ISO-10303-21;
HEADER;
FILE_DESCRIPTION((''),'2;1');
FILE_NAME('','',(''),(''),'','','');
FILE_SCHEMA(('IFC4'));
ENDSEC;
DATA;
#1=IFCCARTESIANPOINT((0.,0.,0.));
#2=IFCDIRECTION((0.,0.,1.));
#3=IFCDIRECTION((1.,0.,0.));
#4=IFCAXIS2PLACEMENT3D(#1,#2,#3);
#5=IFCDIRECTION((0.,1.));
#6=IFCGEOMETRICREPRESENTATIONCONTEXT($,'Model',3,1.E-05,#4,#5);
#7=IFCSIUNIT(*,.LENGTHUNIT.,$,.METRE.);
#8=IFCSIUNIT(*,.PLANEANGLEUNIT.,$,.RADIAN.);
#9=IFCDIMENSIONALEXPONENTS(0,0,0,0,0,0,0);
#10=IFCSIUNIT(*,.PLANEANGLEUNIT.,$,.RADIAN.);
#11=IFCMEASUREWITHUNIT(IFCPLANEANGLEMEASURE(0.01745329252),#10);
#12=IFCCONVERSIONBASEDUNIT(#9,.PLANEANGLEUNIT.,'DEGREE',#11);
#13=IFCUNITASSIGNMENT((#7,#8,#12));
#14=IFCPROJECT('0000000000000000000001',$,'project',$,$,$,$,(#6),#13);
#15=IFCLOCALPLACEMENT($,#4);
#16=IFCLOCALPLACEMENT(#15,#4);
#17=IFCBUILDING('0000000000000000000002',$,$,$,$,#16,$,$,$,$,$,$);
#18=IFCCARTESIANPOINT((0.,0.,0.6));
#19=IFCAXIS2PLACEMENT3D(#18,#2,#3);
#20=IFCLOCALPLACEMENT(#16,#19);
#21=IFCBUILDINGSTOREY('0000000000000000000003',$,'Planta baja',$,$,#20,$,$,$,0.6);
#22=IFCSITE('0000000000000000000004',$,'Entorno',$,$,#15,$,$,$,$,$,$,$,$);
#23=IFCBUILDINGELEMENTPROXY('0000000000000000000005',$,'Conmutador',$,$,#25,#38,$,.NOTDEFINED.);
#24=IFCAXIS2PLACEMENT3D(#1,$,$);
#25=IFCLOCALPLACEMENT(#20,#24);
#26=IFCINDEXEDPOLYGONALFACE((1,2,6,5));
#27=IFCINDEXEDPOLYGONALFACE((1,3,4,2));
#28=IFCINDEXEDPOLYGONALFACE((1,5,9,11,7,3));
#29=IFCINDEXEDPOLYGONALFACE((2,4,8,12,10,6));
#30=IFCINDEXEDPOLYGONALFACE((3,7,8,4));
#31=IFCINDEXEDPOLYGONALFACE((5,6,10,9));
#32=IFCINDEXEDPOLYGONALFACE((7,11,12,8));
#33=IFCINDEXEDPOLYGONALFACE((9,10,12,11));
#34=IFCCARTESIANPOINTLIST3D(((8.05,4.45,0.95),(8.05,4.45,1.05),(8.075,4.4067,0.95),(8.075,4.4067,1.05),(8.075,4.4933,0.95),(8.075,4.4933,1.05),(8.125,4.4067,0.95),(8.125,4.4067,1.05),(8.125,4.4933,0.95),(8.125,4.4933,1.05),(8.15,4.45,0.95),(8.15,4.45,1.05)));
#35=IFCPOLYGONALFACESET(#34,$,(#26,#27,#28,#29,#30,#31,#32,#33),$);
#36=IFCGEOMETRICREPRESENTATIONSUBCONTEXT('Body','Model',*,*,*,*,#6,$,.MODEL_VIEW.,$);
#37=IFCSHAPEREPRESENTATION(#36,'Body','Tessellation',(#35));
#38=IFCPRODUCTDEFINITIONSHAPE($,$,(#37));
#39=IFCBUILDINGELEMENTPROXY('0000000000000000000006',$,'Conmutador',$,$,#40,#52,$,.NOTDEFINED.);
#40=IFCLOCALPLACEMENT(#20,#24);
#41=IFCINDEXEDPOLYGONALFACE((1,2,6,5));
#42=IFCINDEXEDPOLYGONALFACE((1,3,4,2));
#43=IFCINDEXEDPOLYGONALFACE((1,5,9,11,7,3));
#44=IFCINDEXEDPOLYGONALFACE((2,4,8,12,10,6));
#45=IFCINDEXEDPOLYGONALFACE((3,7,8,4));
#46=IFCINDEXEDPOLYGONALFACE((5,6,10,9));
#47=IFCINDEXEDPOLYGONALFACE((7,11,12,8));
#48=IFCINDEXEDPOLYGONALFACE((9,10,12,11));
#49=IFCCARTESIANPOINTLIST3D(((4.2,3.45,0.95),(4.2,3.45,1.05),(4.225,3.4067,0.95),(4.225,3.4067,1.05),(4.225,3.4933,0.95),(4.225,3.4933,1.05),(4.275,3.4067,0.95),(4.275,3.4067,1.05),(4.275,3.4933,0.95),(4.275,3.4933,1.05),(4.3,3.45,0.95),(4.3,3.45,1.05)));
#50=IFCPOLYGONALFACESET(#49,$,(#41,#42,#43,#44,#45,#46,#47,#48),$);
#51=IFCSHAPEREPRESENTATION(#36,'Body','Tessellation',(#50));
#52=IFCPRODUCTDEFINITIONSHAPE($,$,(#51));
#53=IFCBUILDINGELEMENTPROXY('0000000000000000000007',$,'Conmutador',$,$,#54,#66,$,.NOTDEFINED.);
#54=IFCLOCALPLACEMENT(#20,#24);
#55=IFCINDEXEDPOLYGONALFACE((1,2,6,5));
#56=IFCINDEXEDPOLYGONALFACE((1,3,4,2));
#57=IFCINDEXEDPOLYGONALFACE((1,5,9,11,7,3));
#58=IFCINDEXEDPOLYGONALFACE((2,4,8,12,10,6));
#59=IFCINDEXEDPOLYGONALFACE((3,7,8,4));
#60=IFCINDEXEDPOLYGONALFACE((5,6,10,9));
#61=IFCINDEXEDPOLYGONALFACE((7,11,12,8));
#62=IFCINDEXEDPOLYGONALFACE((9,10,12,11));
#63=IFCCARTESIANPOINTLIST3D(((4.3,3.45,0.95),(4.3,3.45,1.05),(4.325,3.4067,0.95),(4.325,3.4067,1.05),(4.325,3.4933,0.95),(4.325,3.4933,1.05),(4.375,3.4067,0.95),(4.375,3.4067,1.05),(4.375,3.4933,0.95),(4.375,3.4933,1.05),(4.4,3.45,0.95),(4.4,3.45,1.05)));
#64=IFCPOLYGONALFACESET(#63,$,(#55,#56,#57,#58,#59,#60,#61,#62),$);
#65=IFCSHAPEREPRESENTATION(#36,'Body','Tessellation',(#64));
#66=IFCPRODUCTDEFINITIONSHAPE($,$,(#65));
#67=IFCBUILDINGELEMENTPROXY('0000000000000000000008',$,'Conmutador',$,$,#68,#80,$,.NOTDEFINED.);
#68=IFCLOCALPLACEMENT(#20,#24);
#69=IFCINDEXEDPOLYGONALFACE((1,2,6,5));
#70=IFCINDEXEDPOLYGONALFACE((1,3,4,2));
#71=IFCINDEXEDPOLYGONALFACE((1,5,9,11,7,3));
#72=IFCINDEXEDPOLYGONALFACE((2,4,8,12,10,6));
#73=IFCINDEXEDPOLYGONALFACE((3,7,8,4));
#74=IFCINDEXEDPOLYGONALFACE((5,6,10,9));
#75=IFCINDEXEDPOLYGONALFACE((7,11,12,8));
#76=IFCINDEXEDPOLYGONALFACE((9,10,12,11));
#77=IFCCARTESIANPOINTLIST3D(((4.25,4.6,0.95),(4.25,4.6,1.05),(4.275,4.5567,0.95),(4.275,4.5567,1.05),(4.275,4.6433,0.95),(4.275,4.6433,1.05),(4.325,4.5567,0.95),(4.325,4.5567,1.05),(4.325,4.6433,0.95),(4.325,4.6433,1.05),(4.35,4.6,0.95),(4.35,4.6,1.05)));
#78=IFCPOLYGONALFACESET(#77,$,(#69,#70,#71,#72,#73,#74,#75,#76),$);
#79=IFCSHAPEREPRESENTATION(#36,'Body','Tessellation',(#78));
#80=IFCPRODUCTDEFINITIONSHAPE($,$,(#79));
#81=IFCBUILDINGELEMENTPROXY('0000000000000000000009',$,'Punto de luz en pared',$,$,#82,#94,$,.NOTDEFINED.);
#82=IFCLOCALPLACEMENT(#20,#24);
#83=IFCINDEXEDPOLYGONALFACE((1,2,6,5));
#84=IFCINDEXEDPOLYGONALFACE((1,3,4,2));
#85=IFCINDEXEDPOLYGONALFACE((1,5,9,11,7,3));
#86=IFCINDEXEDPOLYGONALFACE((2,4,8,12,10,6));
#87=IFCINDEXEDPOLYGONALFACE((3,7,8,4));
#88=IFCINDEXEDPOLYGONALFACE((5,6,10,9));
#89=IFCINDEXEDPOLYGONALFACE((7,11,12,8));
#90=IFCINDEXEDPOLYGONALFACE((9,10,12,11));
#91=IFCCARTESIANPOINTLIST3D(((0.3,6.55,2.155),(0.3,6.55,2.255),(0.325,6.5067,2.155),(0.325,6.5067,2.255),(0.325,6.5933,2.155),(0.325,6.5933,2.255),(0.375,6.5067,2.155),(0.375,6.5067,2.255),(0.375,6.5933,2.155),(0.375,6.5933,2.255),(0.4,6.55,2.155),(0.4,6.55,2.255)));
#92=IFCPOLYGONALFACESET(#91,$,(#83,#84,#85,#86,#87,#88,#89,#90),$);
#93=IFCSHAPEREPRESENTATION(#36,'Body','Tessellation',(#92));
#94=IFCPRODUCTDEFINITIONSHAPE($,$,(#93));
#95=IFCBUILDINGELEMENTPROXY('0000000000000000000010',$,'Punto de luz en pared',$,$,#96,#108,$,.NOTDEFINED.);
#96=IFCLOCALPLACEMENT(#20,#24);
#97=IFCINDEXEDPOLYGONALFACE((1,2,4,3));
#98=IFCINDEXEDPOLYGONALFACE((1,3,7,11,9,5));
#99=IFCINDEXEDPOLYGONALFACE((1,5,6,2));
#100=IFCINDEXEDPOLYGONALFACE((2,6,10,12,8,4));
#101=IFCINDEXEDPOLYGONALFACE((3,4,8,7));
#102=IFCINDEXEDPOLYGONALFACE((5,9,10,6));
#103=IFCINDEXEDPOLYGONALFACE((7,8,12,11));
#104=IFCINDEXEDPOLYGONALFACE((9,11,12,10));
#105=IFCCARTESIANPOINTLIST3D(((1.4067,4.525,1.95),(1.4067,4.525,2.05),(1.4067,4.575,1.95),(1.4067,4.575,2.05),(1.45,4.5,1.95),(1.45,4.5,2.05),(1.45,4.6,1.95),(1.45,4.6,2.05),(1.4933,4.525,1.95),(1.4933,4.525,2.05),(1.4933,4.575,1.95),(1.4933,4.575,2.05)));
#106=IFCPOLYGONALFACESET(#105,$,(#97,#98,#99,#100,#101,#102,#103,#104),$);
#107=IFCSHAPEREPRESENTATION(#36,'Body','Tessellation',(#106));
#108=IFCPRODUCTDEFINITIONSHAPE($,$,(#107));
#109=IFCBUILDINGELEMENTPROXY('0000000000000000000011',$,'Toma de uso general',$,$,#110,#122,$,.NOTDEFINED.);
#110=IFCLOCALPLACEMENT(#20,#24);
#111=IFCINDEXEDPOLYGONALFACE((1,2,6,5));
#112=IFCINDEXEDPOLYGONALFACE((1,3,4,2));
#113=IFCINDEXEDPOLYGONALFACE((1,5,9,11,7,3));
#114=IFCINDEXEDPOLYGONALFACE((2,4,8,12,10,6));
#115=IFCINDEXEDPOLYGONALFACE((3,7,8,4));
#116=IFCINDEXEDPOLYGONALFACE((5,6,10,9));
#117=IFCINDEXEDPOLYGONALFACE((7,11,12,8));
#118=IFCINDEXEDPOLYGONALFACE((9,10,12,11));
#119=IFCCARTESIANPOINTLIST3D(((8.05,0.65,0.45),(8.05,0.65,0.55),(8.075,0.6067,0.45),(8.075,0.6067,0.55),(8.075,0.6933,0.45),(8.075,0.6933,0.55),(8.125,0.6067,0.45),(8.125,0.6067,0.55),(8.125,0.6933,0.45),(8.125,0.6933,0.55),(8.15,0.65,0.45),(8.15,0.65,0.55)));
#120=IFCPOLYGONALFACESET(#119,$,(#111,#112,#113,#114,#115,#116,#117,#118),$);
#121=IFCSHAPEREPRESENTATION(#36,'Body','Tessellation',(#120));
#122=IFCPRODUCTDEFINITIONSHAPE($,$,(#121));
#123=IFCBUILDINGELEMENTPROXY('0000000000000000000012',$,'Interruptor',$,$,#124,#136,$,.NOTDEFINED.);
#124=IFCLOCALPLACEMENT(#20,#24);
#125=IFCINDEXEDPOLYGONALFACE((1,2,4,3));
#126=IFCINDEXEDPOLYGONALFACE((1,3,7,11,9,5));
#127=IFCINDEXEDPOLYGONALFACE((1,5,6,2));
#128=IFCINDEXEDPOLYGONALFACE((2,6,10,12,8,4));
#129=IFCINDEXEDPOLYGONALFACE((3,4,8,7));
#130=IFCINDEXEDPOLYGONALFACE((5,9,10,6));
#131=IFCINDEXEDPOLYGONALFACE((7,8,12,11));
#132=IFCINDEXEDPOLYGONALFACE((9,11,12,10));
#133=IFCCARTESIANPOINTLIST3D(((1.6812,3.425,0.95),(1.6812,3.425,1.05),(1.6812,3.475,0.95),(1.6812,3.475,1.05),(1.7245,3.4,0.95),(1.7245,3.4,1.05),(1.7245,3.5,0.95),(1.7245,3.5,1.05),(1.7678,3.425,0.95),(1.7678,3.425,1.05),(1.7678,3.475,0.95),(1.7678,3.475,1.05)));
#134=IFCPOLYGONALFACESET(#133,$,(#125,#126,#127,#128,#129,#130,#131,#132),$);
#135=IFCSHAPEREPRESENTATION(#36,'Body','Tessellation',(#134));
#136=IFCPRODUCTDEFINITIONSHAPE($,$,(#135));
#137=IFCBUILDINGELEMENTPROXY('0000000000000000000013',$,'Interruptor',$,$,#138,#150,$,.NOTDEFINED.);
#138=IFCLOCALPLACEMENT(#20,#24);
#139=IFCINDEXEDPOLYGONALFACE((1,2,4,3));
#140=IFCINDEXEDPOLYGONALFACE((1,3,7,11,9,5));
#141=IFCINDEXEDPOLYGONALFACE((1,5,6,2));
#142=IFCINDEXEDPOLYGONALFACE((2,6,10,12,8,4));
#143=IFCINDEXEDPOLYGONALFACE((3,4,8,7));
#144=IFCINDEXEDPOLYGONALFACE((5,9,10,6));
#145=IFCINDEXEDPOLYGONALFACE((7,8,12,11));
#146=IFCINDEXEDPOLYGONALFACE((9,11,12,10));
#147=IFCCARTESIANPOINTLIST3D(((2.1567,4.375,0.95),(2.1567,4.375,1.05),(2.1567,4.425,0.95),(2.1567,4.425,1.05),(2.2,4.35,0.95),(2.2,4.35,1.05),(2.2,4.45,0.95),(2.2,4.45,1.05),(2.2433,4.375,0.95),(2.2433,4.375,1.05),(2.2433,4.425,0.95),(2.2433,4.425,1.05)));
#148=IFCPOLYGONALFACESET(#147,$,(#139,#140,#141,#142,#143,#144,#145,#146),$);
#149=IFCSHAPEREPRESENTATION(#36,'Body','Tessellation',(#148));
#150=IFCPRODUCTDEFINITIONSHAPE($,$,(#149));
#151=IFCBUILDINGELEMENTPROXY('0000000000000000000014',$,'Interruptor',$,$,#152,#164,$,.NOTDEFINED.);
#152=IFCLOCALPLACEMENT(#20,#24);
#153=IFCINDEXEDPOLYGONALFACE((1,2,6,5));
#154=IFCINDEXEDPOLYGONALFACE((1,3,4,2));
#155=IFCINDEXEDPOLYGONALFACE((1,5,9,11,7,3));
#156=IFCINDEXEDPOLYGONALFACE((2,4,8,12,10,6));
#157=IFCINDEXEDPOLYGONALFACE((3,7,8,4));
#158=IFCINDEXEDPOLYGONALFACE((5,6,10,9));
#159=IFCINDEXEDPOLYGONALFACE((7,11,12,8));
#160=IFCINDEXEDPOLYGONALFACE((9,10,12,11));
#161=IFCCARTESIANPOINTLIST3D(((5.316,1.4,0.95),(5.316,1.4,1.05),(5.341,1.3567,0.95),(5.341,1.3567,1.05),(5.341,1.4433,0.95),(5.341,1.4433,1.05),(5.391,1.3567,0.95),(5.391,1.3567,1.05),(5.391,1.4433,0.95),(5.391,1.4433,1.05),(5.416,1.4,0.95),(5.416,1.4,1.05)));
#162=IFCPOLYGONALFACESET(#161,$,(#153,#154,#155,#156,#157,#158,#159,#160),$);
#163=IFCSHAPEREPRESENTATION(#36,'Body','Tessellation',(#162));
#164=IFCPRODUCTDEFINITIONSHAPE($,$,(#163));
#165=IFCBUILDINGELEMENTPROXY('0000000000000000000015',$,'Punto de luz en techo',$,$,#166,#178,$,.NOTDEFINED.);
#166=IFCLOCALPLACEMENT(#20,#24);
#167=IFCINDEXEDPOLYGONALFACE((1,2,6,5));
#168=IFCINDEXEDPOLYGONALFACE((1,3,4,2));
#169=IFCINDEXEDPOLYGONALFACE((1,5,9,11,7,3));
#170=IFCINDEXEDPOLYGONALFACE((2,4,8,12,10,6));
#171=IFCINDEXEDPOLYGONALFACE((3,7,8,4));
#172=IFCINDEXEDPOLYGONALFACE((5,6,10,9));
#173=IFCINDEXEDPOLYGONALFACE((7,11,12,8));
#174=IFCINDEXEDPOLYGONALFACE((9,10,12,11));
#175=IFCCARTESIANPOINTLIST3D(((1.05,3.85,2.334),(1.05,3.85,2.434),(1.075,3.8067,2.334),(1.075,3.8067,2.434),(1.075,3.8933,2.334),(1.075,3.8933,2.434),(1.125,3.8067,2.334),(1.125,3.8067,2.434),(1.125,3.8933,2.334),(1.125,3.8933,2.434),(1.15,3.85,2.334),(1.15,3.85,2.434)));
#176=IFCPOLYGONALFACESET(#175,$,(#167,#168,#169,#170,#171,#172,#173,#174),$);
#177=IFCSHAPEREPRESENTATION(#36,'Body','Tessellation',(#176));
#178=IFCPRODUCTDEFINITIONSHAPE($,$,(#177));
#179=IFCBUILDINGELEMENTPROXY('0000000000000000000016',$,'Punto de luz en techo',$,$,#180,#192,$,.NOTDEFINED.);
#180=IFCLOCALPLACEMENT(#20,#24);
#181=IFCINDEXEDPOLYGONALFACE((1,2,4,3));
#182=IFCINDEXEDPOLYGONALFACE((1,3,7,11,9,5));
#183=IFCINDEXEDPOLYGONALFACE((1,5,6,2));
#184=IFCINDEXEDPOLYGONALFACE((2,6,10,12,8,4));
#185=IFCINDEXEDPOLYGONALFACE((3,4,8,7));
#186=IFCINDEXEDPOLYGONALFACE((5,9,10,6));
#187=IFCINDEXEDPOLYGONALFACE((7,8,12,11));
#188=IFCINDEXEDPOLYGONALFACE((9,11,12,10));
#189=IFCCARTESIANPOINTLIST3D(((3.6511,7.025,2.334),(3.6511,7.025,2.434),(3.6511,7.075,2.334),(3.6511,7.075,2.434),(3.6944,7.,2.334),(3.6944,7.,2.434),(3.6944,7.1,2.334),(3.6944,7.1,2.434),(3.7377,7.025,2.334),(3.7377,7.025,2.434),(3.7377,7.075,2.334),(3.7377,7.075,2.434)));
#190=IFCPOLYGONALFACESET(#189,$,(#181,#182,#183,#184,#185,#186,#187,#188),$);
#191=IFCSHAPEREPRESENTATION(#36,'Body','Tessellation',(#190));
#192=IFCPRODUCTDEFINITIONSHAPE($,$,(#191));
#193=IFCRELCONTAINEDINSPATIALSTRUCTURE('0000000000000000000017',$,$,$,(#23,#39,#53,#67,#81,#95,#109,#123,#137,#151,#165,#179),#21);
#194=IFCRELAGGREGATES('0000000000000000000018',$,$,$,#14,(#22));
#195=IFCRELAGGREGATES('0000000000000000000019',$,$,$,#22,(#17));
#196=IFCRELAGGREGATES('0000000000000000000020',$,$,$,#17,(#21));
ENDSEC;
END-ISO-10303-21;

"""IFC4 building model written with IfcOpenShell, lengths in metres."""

from ifc_helpers import new_model, entity, si_unit, converted_unit, direction, frame, origin_with_axes, place, context, subcontext, project, spatial, polyline, outline, extrude, source, transform, mapped, element, save


model = new_model("IFC4")

# Units and contexts
model_context = context("Model", 3, precision=1e-05, world=origin_with_axes(), true_north=direction((0.0, 1.0)))
body_context = subcontext(model_context, "Body", "Model", "MODEL_VIEW")
ifc_project = project(units=[si_unit("LENGTHUNIT", "METRE"), si_unit("PLANEANGLEUNIT", "RADIAN"), converted_unit("PLANEANGLEUNIT", "DEGREE", entity("IfcPlaneAngleMeasure", 0.01745329252), si_unit("PLANEANGLEUNIT", "RADIAN"), dimensions=[0, 0, 0, 0, 0, 0, 0])], contexts=[model_context])

# Site, building, storey
site_placement = place(None, origin_with_axes())
site = spatial("IfcSite", under=ifc_project, at=site_placement, Name="Entorno")
building_placement = place(site_placement, origin_with_axes())
building = spatial("IfcBuilding", under=site, at=building_placement)
storey_placement = place(building_placement, frame((0.0, 0.0, 0.6), z_axis=(0.0, 0.0, 1.0), x_axis=(1.0, 0.0, 0.0)))
storey = spatial("IfcBuildingStorey", under=building, at=storey_placement, Name="Planta baja", Elevation=0.6)

# Building element proxies
shared_shape_1 = source(origin_with_axes(), body_context, "Body", "SolidModel", [
    extrude(outline(polyline([(0.05, 0.0), (0.025, 0.0433), (-0.025, 0.0433), (-0.05, 0.0), (-0.025, -0.0433), (0.025, -0.0433), (0.05, 0.0)])), frame((0.0, 0.0, -0.05), z_axis=(0.0, 0.0, 1.0), x_axis=(1.0, 0.0, 0.0)), (0.0, 0.0, 1.0), 0.1),
])
proxy_1_placement = place(storey_placement, frame((0.0, 0.0, -0.6), z_axis=(0.0, 0.0, 1.0), x_axis=(1.0, 0.0, 0.0)))
element("IfcBuildingElementProxy", 1, at=proxy_1_placement, inside=storey, Name="Conmutador", PredefinedType="NOTDEFINED", context=body_context, shape_type="Brep", body=[
    mapped(shared_shape_1, transform((8.1, 4.45, 1.6), x_axis=(1.0, 0.0, 0.0), y_axis=(0.0, 1.0, 0.0), z_axis=(0.0, 0.0, 1.0))),
])
proxy_2_placement = place(storey_placement, frame((0.0, 0.0, -0.6), z_axis=(0.0, 0.0, 1.0), x_axis=(1.0, 0.0, 0.0)))
element("IfcBuildingElementProxy", 2, at=proxy_2_placement, inside=storey, Name="Conmutador", PredefinedType="NOTDEFINED", context=body_context, shape_type="Brep", body=[
    mapped(shared_shape_1, transform((4.25, 3.45, 1.6), x_axis=(1.0, 0.0, 0.0), y_axis=(0.0, 1.0, 0.0), z_axis=(0.0, 0.0, 1.0))),
])
proxy_3_placement = place(storey_placement, frame((0.0, 0.0, -0.6), z_axis=(0.0, 0.0, 1.0), x_axis=(1.0, 0.0, 0.0)))
element("IfcBuildingElementProxy", 3, at=proxy_3_placement, inside=storey, Name="Conmutador", PredefinedType="NOTDEFINED", context=body_context, shape_type="Brep", body=[
    mapped(shared_shape_1, transform((4.35, 3.45, 1.6), x_axis=(1.0, 0.0, 0.0), y_axis=(0.0, 1.0, 0.0), z_axis=(0.0, 0.0, 1.0))),
])
proxy_4_placement = place(storey_placement, frame((0.0, 0.0, -0.6), z_axis=(0.0, 0.0, 1.0), x_axis=(1.0, 0.0, 0.0)))
element("IfcBuildingElementProxy", 4, at=proxy_4_placement, inside=storey, Name="Conmutador", PredefinedType="NOTDEFINED", context=body_context, shape_type="Brep", body=[
    mapped(shared_shape_1, transform((4.3, 4.6, 1.6), x_axis=(1.0, 0.0, 0.0), y_axis=(0.0, 1.0, 0.0), z_axis=(0.0, 0.0, 1.0))),
])
shared_shape_2 = source(origin_with_axes(), body_context, "Body", "SolidModel", [
    extrude(outline(polyline([(0.05, 0.0), (0.025, 0.0433), (-0.025, 0.0433), (-0.05, 0.0), (-0.025, -0.0433), (0.025, -0.0433), (0.05, 0.0)])), frame((0.0, 0.0, -0.05), z_axis=(0.0, 0.0, 1.0), x_axis=(1.0, 0.0, 0.0)), (0.0, 0.0, 1.0), 0.1),
])
proxy_5_placement = place(storey_placement, frame((0.0, 0.0, -0.6), z_axis=(0.0, 0.0, 1.0), x_axis=(1.0, 0.0, 0.0)))
element("IfcBuildingElementProxy", 5, at=proxy_5_placement, inside=storey, Name="Punto de luz en pared", PredefinedType="NOTDEFINED", context=body_context, shape_type="Brep", body=[
    mapped(shared_shape_2, transform((0.35, 6.55, 2.805), x_axis=(1.0, 0.0, 0.0), y_axis=(0.0, 1.0, 0.0), z_axis=(0.0, 0.0, 1.0))),
])
proxy_6_placement = place(storey_placement, frame((0.0, 0.0, -0.6), z_axis=(0.0, 0.0, 1.0), x_axis=(1.0, 0.0, 0.0)))
element("IfcBuildingElementProxy", 6, at=proxy_6_placement, inside=storey, Name="Punto de luz en pared", PredefinedType="NOTDEFINED", context=body_context, shape_type="Brep", body=[
    mapped(shared_shape_2, transform((1.45, 4.55, 2.6), x_axis=(0.0, -1.0, 0.0), y_axis=(1.0, 0.0, 0.0), z_axis=(0.0, 0.0, 1.0))),
])
shared_shape_3 = source(origin_with_axes(), body_context, "Body", "SolidModel", [
    extrude(outline(polyline([(0.05, 0.0), (0.025, 0.0433), (-0.025, 0.0433), (-0.05, 0.0), (-0.025, -0.0433), (0.025, -0.0433), (0.05, 0.0)])), frame((0.0, 0.0, -0.05), z_axis=(0.0, 0.0, 1.0), x_axis=(1.0, 0.0, 0.0)), (0.0, 0.0, 1.0), 0.1),
])
proxy_7_placement = place(storey_placement, frame((0.0, 0.0, -0.6), z_axis=(0.0, 0.0, 1.0), x_axis=(1.0, 0.0, 0.0)))
element("IfcBuildingElementProxy", 7, at=proxy_7_placement, inside=storey, Name="Toma de uso general", PredefinedType="NOTDEFINED", context=body_context, shape_type="Brep", body=[
    mapped(shared_shape_3, transform((8.1, 0.65, 1.1), x_axis=(-1.0, 0.0, 0.0), y_axis=(0.0, -1.0, 0.0), z_axis=(0.0, 0.0, 1.0))),
])
shared_shape_4 = source(origin_with_axes(), body_context, "Body", "SolidModel", [
    extrude(outline(polyline([(0.05, 0.0), (0.025, 0.0433), (-0.025, 0.0433), (-0.05, 0.0), (-0.025, -0.0433), (0.025, -0.0433), (0.05, 0.0)])), frame((0.0, 0.0, -0.05), z_axis=(0.0, 0.0, 1.0), x_axis=(1.0, 0.0, 0.0)), (0.0, 0.0, 1.0), 0.1),
])
proxy_8_placement = place(storey_placement, frame((0.0, 0.0, -0.6), z_axis=(0.0, 0.0, 1.0), x_axis=(1.0, 0.0, 0.0)))
element("IfcBuildingElementProxy", 8, at=proxy_8_placement, inside=storey, Name="Interruptor", PredefinedType="NOTDEFINED", context=body_context, shape_type="Brep", body=[
    mapped(shared_shape_4, transform((1.7245, 3.45, 1.6), x_axis=(0.0, 1.0, 0.0), y_axis=(-1.0, 0.0, 0.0), z_axis=(0.0, 0.0, 1.0))),
])
proxy_9_placement = place(storey_placement, frame((0.0, 0.0, -0.6), z_axis=(0.0, 0.0, 1.0), x_axis=(1.0, 0.0, 0.0)))
element("IfcBuildingElementProxy", 9, at=proxy_9_placement, inside=storey, Name="Interruptor", PredefinedType="NOTDEFINED", context=body_context, shape_type="Brep", body=[
    mapped(shared_shape_4, transform((2.2, 4.4, 1.6), x_axis=(0.0, 1.0, 0.0), y_axis=(-1.0, 0.0, 0.0), z_axis=(0.0, 0.0, 1.0))),
])
proxy_10_placement = place(storey_placement, frame((0.0, 0.0, -0.6), z_axis=(0.0, 0.0, 1.0), x_axis=(1.0, 0.0, 0.0)))
element("IfcBuildingElementProxy", 10, at=proxy_10_placement, inside=storey, Name="Interruptor", PredefinedType="NOTDEFINED", context=body_context, shape_type="Brep", body=[
    mapped(shared_shape_4, transform((5.366, 1.4, 1.6), x_axis=(-1.0, 0.0, 0.0), y_axis=(0.0, -1.0, 0.0), z_axis=(0.0, 0.0, 1.0))),
])
shared_shape_5 = source(origin_with_axes(), body_context, "Body", "SolidModel", [
    extrude(outline(polyline([(0.05, 0.0), (0.025, 0.0433), (-0.025, 0.0433), (-0.05, 0.0), (-0.025, -0.0433), (0.025, -0.0433), (0.05, 0.0)])), frame((0.0, 0.0, -0.05), z_axis=(0.0, 0.0, 1.0), x_axis=(1.0, 0.0, 0.0)), (0.0, 0.0, 1.0), 0.1),
])
proxy_11_placement = place(storey_placement, frame((0.0, 0.0, -0.6), z_axis=(0.0, 0.0, 1.0), x_axis=(1.0, 0.0, 0.0)))
element("IfcBuildingElementProxy", 11, at=proxy_11_placement, inside=storey, Name="Punto de luz en techo", PredefinedType="NOTDEFINED", context=body_context, shape_type="Brep", body=[
    mapped(shared_shape_5, transform((1.1, 3.85, 2.984), x_axis=(1.0, 0.0, 0.0), y_axis=(0.0, 1.0, 0.0), z_axis=(0.0, 0.0, 1.0))),
])
proxy_12_placement = place(storey_placement, frame((0.0, 0.0, -0.6), z_axis=(0.0, 0.0, 1.0), x_axis=(1.0, 0.0, 0.0)))
element("IfcBuildingElementProxy", 12, at=proxy_12_placement, inside=storey, Name="Punto de luz en techo", PredefinedType="NOTDEFINED", context=body_context, shape_type="Brep", body=[
    mapped(shared_shape_5, transform((3.6944, 7.05, 2.984), x_axis=(0.0, 1.0, 0.0), y_axis=(-1.0, 0.0, 0.0), z_axis=(0.0, 0.0, 1.0))),
])

save(model, "model.ifc")
